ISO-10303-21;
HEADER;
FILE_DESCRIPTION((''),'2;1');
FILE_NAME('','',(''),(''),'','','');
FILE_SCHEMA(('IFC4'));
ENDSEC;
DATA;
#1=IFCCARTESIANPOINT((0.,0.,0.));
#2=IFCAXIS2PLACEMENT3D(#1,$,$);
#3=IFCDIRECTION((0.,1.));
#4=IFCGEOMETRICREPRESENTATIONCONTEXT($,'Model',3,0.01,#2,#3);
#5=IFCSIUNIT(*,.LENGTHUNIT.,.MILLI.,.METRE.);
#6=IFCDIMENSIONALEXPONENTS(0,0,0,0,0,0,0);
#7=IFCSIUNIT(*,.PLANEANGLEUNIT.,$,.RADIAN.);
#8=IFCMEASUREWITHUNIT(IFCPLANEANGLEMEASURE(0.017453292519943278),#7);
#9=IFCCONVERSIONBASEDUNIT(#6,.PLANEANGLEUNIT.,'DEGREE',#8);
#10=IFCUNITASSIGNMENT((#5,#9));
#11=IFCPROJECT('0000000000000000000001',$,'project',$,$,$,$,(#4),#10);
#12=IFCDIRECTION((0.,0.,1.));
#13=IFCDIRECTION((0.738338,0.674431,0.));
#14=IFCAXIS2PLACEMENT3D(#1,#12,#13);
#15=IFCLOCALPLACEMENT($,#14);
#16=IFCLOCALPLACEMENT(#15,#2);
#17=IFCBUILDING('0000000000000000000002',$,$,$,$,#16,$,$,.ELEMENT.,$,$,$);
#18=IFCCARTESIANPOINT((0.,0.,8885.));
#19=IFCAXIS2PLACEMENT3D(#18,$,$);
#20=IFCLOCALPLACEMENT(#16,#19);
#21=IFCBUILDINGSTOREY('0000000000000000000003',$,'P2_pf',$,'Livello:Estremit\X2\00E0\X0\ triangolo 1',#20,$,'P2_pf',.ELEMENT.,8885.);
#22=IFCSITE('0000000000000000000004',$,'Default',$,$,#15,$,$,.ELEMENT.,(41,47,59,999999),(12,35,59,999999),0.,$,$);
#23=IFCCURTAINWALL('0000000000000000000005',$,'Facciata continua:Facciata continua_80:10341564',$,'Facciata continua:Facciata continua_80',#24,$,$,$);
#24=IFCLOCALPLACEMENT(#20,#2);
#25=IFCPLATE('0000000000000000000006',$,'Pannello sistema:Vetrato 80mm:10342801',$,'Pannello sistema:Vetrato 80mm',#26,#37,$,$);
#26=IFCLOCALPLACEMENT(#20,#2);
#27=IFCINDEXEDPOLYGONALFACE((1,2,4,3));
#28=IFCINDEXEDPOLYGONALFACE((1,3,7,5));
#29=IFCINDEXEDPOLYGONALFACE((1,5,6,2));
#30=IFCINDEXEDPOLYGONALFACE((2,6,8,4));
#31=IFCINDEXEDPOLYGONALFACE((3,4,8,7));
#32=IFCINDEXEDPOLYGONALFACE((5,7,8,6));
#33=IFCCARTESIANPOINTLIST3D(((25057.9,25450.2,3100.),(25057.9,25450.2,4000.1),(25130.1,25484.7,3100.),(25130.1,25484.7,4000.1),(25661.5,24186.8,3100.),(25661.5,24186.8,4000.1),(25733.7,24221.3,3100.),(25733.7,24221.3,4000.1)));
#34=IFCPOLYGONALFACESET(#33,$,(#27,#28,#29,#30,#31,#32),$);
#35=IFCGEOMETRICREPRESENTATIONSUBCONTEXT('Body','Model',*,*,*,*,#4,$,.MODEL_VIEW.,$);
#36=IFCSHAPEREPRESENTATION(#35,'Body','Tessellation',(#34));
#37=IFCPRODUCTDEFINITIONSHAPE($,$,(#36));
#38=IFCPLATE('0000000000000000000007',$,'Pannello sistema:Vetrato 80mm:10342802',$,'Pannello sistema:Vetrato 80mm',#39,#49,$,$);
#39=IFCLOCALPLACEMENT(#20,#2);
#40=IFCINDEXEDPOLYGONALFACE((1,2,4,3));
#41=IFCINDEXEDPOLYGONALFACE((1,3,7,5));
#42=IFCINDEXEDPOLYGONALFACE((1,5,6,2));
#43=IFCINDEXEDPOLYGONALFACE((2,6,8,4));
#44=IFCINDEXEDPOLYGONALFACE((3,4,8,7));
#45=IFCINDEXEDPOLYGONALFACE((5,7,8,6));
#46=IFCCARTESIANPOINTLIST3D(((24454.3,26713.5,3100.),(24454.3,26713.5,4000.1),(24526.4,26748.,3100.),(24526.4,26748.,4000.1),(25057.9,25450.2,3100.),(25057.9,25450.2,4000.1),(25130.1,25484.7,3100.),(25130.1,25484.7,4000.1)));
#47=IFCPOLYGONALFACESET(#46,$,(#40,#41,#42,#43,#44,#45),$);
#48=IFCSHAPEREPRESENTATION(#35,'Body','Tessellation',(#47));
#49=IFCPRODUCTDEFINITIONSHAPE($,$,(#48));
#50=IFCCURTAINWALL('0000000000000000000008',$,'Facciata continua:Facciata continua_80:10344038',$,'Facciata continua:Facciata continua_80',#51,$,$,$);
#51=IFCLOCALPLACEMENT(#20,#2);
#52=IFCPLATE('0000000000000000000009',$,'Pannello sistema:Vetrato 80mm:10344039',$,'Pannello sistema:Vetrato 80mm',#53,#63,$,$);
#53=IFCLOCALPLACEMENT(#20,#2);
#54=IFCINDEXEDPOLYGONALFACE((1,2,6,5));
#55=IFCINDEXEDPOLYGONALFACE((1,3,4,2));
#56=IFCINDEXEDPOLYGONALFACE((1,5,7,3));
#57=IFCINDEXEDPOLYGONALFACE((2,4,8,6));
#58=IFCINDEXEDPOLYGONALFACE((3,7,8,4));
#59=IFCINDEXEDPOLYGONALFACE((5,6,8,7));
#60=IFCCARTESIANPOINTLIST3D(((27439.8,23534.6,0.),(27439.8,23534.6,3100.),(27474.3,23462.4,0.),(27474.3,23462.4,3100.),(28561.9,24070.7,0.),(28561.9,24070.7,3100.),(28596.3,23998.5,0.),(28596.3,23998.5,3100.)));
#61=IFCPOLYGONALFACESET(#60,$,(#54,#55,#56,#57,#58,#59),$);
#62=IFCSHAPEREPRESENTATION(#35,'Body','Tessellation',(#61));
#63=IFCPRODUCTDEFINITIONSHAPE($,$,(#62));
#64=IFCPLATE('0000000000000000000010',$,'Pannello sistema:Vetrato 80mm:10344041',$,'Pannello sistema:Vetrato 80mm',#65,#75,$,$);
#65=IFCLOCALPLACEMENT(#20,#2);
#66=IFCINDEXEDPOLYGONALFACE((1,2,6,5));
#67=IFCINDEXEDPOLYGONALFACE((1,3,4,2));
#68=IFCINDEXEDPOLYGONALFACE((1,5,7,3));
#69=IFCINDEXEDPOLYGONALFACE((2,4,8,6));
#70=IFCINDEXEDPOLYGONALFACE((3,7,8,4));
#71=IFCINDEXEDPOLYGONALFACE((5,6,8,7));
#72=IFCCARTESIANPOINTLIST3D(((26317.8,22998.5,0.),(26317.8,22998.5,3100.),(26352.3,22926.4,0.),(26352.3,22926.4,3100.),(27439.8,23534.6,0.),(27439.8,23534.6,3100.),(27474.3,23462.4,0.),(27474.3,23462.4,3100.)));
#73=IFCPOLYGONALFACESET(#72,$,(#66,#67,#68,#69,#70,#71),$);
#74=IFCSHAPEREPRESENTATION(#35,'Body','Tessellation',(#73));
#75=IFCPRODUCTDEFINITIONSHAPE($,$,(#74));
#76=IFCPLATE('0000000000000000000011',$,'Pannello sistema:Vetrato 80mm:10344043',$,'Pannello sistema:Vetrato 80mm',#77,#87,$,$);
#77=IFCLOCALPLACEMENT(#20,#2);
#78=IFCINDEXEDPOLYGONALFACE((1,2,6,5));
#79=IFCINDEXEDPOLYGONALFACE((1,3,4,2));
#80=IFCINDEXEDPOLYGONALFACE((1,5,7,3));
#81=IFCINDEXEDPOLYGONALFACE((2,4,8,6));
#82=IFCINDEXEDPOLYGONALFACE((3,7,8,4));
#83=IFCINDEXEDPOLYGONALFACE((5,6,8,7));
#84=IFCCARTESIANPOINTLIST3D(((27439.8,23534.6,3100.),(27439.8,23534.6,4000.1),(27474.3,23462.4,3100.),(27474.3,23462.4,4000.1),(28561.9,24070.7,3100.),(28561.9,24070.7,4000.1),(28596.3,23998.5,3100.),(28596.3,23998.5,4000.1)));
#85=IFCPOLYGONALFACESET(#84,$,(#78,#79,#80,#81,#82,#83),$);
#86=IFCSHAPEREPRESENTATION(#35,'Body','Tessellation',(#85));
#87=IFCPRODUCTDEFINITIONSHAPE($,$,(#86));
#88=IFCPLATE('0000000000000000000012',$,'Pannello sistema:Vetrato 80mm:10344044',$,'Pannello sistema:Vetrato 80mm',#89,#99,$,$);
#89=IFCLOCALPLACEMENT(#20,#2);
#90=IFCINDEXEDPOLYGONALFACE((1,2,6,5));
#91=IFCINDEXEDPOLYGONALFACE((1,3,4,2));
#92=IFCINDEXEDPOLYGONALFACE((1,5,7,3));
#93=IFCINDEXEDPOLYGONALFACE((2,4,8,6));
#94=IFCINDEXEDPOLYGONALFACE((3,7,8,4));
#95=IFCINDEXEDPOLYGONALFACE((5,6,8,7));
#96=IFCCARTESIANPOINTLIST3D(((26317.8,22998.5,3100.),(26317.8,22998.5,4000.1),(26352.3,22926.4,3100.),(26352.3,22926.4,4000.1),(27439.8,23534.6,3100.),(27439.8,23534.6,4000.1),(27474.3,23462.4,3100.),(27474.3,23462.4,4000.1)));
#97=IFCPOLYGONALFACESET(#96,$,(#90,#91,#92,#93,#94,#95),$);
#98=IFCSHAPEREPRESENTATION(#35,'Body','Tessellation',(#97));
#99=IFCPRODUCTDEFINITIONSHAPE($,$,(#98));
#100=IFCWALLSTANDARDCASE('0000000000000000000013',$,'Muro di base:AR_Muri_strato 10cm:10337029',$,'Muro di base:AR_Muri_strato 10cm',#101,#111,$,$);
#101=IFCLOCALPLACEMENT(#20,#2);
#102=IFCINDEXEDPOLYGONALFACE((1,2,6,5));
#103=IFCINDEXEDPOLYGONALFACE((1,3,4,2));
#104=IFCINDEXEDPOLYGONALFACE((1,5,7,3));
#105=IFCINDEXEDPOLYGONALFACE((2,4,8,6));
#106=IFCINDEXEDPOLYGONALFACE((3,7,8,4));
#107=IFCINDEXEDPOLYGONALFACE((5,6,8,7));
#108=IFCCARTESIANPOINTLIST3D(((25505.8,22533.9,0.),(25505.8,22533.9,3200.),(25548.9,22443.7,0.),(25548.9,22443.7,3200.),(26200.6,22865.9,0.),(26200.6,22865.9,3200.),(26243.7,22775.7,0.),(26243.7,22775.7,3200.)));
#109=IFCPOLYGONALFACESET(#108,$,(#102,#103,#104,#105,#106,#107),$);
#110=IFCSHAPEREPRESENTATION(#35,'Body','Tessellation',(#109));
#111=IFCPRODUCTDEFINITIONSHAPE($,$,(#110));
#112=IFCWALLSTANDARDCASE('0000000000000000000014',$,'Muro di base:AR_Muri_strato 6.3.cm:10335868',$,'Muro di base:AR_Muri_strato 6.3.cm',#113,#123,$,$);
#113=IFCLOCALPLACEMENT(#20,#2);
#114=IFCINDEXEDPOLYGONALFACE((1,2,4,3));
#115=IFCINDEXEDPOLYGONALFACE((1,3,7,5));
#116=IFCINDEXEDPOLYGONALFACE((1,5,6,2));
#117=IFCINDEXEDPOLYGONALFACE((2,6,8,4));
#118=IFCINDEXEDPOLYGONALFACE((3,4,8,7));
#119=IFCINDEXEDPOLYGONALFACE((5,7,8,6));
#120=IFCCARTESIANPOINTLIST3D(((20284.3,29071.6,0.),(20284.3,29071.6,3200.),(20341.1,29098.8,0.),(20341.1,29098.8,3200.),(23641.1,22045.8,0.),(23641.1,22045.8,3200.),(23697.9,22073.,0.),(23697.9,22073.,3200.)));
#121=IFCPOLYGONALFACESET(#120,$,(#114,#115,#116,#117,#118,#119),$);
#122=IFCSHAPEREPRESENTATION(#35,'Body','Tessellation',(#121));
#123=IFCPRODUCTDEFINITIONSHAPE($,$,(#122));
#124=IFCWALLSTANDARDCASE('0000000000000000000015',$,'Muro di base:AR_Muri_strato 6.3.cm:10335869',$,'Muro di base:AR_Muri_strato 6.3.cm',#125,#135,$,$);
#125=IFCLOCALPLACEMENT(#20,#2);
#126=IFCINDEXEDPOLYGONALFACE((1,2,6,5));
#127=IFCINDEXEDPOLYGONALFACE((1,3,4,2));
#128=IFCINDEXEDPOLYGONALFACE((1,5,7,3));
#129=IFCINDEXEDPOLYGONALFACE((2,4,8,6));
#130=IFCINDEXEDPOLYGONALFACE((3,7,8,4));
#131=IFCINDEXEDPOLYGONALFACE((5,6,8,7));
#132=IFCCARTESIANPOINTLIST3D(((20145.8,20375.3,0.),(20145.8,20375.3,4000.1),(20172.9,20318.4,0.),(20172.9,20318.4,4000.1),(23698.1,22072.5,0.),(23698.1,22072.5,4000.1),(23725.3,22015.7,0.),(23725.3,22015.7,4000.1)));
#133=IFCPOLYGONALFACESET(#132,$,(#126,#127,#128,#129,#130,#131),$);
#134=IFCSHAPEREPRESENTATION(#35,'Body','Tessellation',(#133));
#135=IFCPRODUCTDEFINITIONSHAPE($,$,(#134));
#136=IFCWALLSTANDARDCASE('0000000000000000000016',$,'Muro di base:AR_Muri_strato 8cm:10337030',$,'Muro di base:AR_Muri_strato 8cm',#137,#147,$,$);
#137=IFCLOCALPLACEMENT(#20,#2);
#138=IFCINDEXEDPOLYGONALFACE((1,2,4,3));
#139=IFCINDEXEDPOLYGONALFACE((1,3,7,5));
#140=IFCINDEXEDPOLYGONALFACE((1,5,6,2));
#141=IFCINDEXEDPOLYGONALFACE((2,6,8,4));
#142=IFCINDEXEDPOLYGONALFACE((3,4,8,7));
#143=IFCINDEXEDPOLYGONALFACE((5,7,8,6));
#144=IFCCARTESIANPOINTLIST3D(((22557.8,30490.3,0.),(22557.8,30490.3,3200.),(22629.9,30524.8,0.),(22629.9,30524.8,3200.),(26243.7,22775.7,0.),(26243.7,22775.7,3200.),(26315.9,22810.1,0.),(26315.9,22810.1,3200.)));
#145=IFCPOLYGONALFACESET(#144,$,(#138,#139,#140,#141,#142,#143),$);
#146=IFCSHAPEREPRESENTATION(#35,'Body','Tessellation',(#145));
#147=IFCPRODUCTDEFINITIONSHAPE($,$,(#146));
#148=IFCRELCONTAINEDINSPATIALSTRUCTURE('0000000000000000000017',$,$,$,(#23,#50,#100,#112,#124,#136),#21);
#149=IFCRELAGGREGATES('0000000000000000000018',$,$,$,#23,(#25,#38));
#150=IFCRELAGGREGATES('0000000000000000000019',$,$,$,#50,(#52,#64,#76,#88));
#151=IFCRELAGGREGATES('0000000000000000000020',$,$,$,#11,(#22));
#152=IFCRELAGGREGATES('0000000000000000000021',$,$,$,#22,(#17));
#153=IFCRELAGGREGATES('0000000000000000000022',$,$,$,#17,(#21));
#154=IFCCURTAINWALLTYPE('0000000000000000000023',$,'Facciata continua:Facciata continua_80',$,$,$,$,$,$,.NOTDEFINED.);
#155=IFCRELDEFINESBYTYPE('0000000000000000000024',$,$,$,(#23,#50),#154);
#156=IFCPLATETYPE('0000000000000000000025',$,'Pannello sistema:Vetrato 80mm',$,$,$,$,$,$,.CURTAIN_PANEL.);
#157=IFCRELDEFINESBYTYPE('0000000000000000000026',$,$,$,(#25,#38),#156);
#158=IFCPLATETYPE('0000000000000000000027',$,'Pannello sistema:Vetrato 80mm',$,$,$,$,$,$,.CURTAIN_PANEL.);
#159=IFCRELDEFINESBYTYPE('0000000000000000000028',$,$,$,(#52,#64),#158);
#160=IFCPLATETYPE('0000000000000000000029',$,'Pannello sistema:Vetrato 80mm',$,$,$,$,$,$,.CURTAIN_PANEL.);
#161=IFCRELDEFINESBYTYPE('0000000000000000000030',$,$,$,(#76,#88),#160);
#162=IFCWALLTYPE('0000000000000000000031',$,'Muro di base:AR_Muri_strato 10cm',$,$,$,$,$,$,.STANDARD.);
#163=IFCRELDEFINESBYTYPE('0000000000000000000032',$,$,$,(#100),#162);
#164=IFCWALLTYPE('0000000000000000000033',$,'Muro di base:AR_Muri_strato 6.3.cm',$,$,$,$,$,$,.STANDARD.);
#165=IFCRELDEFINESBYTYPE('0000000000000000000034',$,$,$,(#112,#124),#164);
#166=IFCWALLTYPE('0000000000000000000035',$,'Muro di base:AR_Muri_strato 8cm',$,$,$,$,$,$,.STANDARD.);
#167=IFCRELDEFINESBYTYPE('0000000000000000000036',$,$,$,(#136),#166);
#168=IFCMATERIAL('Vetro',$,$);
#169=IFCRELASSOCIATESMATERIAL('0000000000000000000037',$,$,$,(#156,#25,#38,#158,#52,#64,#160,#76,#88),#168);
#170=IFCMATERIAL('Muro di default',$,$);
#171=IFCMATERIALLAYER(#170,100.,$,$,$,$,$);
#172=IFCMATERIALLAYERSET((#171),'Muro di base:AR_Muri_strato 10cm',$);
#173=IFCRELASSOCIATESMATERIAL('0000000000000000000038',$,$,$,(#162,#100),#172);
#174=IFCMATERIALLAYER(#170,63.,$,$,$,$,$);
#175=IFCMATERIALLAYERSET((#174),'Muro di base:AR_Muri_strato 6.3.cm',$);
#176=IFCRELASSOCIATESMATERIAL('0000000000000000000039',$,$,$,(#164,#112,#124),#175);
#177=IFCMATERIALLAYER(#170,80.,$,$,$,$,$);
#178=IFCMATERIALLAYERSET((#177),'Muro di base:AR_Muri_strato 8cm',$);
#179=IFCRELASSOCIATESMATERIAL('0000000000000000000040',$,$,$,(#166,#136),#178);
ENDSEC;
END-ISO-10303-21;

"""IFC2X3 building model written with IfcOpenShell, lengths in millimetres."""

from ifc_helpers import new_model, entity, si_unit, converted_unit, direction, frame, frame_2d, origin, place, context, subcontext, project, spatial, rectangle, extrude, source, transform, mapped, material, layer, layer_set, layer_usage, type_object, type_shapes, element, aggregate, save


model = new_model("IFC2X3")

# Units and contexts
model_context = context("Model", 3, precision=0.01, world=origin(), true_north=direction((0.0, 1.0)))
body_context = subcontext(model_context, "Body", "Model", "MODEL_VIEW")
ifc_project = project(units=[si_unit("LENGTHUNIT", "METRE", prefix="MILLI"), converted_unit("PLANEANGLEUNIT", "DEGREE", entity("IfcPlaneAngleMeasure", 0.017453292519943278), si_unit("PLANEANGLEUNIT", "RADIAN"), dimensions=[0, 0, 0, 0, 0, 0, 0])], contexts=[model_context])

# Site, building, storey
site_placement = place(None, frame((0.0, 0.0, 0.0), z_axis=(0.0, 0.0, 1.0), x_axis=(0.738338, 0.674431, 0.0)))
site = spatial("IfcSite", under=ifc_project, at=site_placement, Name="Default", CompositionType="ELEMENT", RefLatitude=(41, 47, 59, 999999), RefLongitude=(12, 35, 59, 999999), RefElevation=0.0)
building_placement = place(site_placement, origin())
building = spatial("IfcBuilding", under=site, at=building_placement, CompositionType="ELEMENT")
storey_placement = place(building_placement, frame((0.0, 0.0, 8885.0)))
storey = spatial("IfcBuildingStorey", under=building, at=storey_placement, Name="P2_pf", ObjectType="Livello:Estremità triangolo 1", LongName="P2_pf", CompositionType="ELEMENT", Elevation=8885.0)

# Shared definitions
ifc_material_1 = material(Name="Vetro")

# Curtain walls, plates
curtain_wall_type_1 = type_object("IfcCurtainWallType", Name="Facciata continua:Facciata continua_80", PredefinedType="NOTDEFINED")
curtain_wall_1_placement = place(storey_placement, frame((0.0, 0.0, -8885.0)))
curtain_wall_1 = element("IfcCurtainWall", 1, at=curtain_wall_1_placement, inside=storey, type_object=curtain_wall_type_1, Name="Facciata continua:Facciata continua_80:10341564", ObjectType="Facciata continua:Facciata continua_80")
plate_type_1 = type_object("IfcPlateType", Name="Pannello sistema:Vetrato 80mm", PredefinedType="CURTAIN_PANEL", material=ifc_material_1)
shared_shape_1 = source(origin(), body_context, "Body", "SweptSolid", [
    extrude(rectangle(XDim=80.0, YDim=1400.1, at=frame_2d((0.0, 0.0), x_axis=(1.0, 0.0))), frame((0.0, -40.0, 0.0), z_axis=(0.0, 0.0, 1.0), x_axis=(0.0, 1.0, 0.0)), (0.0, 0.0, 1.0), 900.1),
])
type_shapes(plate_type_1, [shared_shape_1])
plate_1_placement = place(curtain_wall_1_placement, frame((25359.7, 24818.5, 11985.0), z_axis=(0.0, 0.0, 1.0), x_axis=(-0.431105, 0.902302, 0.0)))
plate_1 = element("IfcPlate", 2, at=plate_1_placement, type_object=plate_type_1, material=ifc_material_1, Name="Pannello sistema:Vetrato 80mm:10342801", ObjectType="Pannello sistema:Vetrato 80mm", context=body_context, shape_type="MappedRepresentation", body=[
    mapped(shared_shape_1, transform((0.0, 0.0, 0.0), scale=1.0)),
])
plate_2_placement = place(curtain_wall_1_placement, frame((24756.1, 26081.8, 11985.0), z_axis=(0.0, 0.0, 1.0), x_axis=(-0.431105, 0.902302, 0.0)))
plate_2 = element("IfcPlate", 3, at=plate_2_placement, type_object=plate_type_1, material=ifc_material_1, Name="Pannello sistema:Vetrato 80mm:10342802", ObjectType="Pannello sistema:Vetrato 80mm", context=body_context, shape_type="MappedRepresentation", body=[
    mapped(shared_shape_1, transform((0.0, 0.0, 0.0), scale=1.0)),
])
aggregate(curtain_wall_1, [plate_1, plate_2])
curtain_wall_2_placement = place(storey_placement, frame((0.0, 0.0, -8885.0)))
curtain_wall_2 = element("IfcCurtainWall", 4, at=curtain_wall_2_placement, inside=storey, type_object=curtain_wall_type_1, Name="Facciata continua:Facciata continua_80:10344038", ObjectType="Facciata continua:Facciata continua_80")
plate_type_2 = type_object("IfcPlateType", Name="Pannello sistema:Vetrato 80mm", PredefinedType="CURTAIN_PANEL", material=ifc_material_1)
shared_shape_2 = source(origin(), body_context, "Body", "SweptSolid", [
    extrude(rectangle(XDim=80.0, YDim=1243.5, at=frame_2d((0.0, 0.0), x_axis=(1.0, 0.0))), frame((0.0, -40.0, 0.0), z_axis=(0.0, 0.0, 1.0), x_axis=(0.0, 1.0, 0.0)), (0.0, 0.0, 1.0), 3100.0),
])
type_shapes(plate_type_2, [shared_shape_2])
plate_3_placement = place(curtain_wall_2_placement, frame((28035.3, 23730.5, 8885.0), z_axis=(0.0, 0.0, 1.0), x_axis=(-0.902302, -0.431105, 0.0)))
plate_3 = element("IfcPlate", 5, at=plate_3_placement, type_object=plate_type_2, material=ifc_material_1, Name="Pannello sistema:Vetrato 80mm:10344039", ObjectType="Pannello sistema:Vetrato 80mm", context=body_context, shape_type="MappedRepresentation", body=[
    mapped(shared_shape_2, transform((0.0, 0.0, 0.0), scale=1.0)),
])
plate_4_placement = place(curtain_wall_2_placement, frame((26913.3, 23194.4, 8885.0), z_axis=(0.0, 0.0, 1.0), x_axis=(-0.902302, -0.431105, 0.0)))
plate_4 = element("IfcPlate", 6, at=plate_4_placement, type_object=plate_type_2, material=ifc_material_1, Name="Pannello sistema:Vetrato 80mm:10344041", ObjectType="Pannello sistema:Vetrato 80mm", context=body_context, shape_type="MappedRepresentation", body=[
    mapped(shared_shape_2, transform((0.0, 0.0, 0.0), scale=1.0)),
])
plate_type_3 = type_object("IfcPlateType", Name="Pannello sistema:Vetrato 80mm", PredefinedType="CURTAIN_PANEL", material=ifc_material_1)
shared_shape_3 = source(origin(), body_context, "Body", "SweptSolid", [
    extrude(rectangle(XDim=80.0, YDim=1243.5, at=frame_2d((0.0, 0.0), x_axis=(1.0, 0.0))), frame((0.0, -40.0, 0.0), z_axis=(0.0, 0.0, 1.0), x_axis=(0.0, 1.0, 0.0)), (0.0, 0.0, 1.0), 900.1),
])
type_shapes(plate_type_3, [shared_shape_3])
plate_5_placement = place(curtain_wall_2_placement, frame((28035.3, 23730.5, 11985.0), z_axis=(0.0, 0.0, 1.0), x_axis=(-0.902302, -0.431105, 0.0)))
plate_5 = element("IfcPlate", 7, at=plate_5_placement, type_object=plate_type_3, material=ifc_material_1, Name="Pannello sistema:Vetrato 80mm:10344043", ObjectType="Pannello sistema:Vetrato 80mm", context=body_context, shape_type="MappedRepresentation", body=[
    mapped(shared_shape_3, transform((0.0, 0.0, 0.0), scale=1.0)),
])
plate_6_placement = place(curtain_wall_2_placement, frame((26913.3, 23194.4, 11985.0), z_axis=(0.0, 0.0, 1.0), x_axis=(-0.902302, -0.431105, 0.0)))
plate_6 = element("IfcPlate", 8, at=plate_6_placement, type_object=plate_type_3, material=ifc_material_1, Name="Pannello sistema:Vetrato 80mm:10344044", ObjectType="Pannello sistema:Vetrato 80mm", context=body_context, shape_type="MappedRepresentation", body=[
    mapped(shared_shape_3, transform((0.0, 0.0, 0.0), scale=1.0)),
])
aggregate(curtain_wall_2, [plate_3, plate_4, plate_5, plate_6])

# Walls
ifc_material_2 = material(Name="Muro di default")
ifc_layer_1 = layer(ifc_material_2, 100.0)
ifc_layer_set_1 = layer_set([ifc_layer_1], Name="Muro di base:AR_Muri_strato 10cm")
ifc_layer_usage_1 = layer_usage(ifc_layer_set_1, "AXIS2", "POSITIVE", -50.0)
wall_type_1 = type_object("IfcWallType", Name="Muro di base:AR_Muri_strato 10cm", PredefinedType="STANDARD", material=ifc_layer_set_1)
wall_1_placement = place(storey_placement, frame((26222.2, 22820.8, 0.0), z_axis=(0.0, 0.0, 1.0), x_axis=(-0.902302, -0.431105, 0.0)))
element("IfcWallStandardCase", 9, at=wall_1_placement, inside=storey, type_object=wall_type_1, material=ifc_layer_usage_1, Name="Muro di base:AR_Muri_strato 10cm:10337029", ObjectType="Muro di base:AR_Muri_strato 10cm", context=body_context, shape_type="SweptSolid", body=[
    extrude(rectangle(XDim=770.0, YDim=100.0, at=frame_2d((385.0, 0.0), x_axis=(-1.0, 0.0))), origin(), (0.0, 0.0, 1.0), 3200.0),
])
ifc_layer_2 = layer(ifc_material_2, 63.0)
ifc_layer_set_2 = layer_set([ifc_layer_2], Name="Muro di base:AR_Muri_strato 6.3.cm")
ifc_layer_usage_2 = layer_usage(ifc_layer_set_2, "AXIS2", "NEGATIVE", 31.5)
wall_type_2 = type_object("IfcWallType", Name="Muro di base:AR_Muri_strato 6.3.cm", PredefinedType="STANDARD", material=ifc_layer_set_2)
wall_2_placement = place(storey_placement, frame((23669.5, 22059.4, 0.0), z_axis=(0.0, 0.0, 1.0), x_axis=(-0.431105, 0.902302, 0.0)))
element("IfcWallStandardCase", 10, at=wall_2_placement, inside=storey, type_object=wall_type_2, material=ifc_layer_usage_2, Name="Muro di base:AR_Muri_strato 6.3.cm:10335868", ObjectType="Muro di base:AR_Muri_strato 6.3.cm", context=body_context, shape_type="SweptSolid", body=[
    extrude(rectangle(XDim=7786.5, YDim=63.0, at=frame_2d((3893.2, 0.0), x_axis=(-1.0, 0.0))), origin(), (0.0, 0.0, 1.0), 3200.0),
])
ifc_layer_usage_3 = layer_usage(ifc_layer_set_2, "AXIS2", "NEGATIVE", 31.5)
wall_3_placement = place(storey_placement, frame((20159.3, 20346.9, 0.0), z_axis=(0.0, 0.0, 1.0), x_axis=(0.902302, 0.431105, 0.0)))
element("IfcWallStandardCase", 11, at=wall_3_placement, inside=storey, type_object=wall_type_2, material=ifc_layer_usage_3, Name="Muro di base:AR_Muri_strato 6.3.cm:10335869", ObjectType="Muro di base:AR_Muri_strato 6.3.cm", context=body_context, shape_type="SweptSolid", body=[
    extrude(rectangle(XDim=3937.0, YDim=63.0, at=frame_2d((1968.5, 0.0), x_axis=(-1.0, 0.0))), origin(), (0.0, 0.0, 1.0), 4000.1),
])

# Wall
ifc_layer_3 = layer(ifc_material_2, 80.0)
ifc_layer_set_3 = layer_set([ifc_layer_3], Name="Muro di base:AR_Muri_strato 8cm")
ifc_layer_usage_4 = layer_usage(ifc_layer_set_3, "AXIS2", "NEGATIVE", 40.0)
wall_type_3 = type_object("IfcWallType", Name="Muro di base:AR_Muri_strato 8cm", PredefinedType="STANDARD", material=ifc_layer_set_3)
wall_4_placement = place(storey_placement, frame((26279.8, 22792.9, 0.0), z_axis=(0.0, 0.0, 1.0), x_axis=(-0.431105, 0.902302, 0.0)))
element("IfcWallStandardCase", 12, at=wall_4_placement, inside=storey, type_object=wall_type_3, material=ifc_layer_usage_4, Name="Muro di base:AR_Muri_strato 8cm:10337030", ObjectType="Muro di base:AR_Muri_strato 8cm", context=body_context, shape_type="SweptSolid", body=[
    extrude(rectangle(XDim=8550.0, YDim=80.0, at=frame_2d((4275.0, 0.0), x_axis=(-1.0, 0.0))), origin(), (0.0, 0.0, 1.0), 3200.0),
])

save(model, "model.ifc")
